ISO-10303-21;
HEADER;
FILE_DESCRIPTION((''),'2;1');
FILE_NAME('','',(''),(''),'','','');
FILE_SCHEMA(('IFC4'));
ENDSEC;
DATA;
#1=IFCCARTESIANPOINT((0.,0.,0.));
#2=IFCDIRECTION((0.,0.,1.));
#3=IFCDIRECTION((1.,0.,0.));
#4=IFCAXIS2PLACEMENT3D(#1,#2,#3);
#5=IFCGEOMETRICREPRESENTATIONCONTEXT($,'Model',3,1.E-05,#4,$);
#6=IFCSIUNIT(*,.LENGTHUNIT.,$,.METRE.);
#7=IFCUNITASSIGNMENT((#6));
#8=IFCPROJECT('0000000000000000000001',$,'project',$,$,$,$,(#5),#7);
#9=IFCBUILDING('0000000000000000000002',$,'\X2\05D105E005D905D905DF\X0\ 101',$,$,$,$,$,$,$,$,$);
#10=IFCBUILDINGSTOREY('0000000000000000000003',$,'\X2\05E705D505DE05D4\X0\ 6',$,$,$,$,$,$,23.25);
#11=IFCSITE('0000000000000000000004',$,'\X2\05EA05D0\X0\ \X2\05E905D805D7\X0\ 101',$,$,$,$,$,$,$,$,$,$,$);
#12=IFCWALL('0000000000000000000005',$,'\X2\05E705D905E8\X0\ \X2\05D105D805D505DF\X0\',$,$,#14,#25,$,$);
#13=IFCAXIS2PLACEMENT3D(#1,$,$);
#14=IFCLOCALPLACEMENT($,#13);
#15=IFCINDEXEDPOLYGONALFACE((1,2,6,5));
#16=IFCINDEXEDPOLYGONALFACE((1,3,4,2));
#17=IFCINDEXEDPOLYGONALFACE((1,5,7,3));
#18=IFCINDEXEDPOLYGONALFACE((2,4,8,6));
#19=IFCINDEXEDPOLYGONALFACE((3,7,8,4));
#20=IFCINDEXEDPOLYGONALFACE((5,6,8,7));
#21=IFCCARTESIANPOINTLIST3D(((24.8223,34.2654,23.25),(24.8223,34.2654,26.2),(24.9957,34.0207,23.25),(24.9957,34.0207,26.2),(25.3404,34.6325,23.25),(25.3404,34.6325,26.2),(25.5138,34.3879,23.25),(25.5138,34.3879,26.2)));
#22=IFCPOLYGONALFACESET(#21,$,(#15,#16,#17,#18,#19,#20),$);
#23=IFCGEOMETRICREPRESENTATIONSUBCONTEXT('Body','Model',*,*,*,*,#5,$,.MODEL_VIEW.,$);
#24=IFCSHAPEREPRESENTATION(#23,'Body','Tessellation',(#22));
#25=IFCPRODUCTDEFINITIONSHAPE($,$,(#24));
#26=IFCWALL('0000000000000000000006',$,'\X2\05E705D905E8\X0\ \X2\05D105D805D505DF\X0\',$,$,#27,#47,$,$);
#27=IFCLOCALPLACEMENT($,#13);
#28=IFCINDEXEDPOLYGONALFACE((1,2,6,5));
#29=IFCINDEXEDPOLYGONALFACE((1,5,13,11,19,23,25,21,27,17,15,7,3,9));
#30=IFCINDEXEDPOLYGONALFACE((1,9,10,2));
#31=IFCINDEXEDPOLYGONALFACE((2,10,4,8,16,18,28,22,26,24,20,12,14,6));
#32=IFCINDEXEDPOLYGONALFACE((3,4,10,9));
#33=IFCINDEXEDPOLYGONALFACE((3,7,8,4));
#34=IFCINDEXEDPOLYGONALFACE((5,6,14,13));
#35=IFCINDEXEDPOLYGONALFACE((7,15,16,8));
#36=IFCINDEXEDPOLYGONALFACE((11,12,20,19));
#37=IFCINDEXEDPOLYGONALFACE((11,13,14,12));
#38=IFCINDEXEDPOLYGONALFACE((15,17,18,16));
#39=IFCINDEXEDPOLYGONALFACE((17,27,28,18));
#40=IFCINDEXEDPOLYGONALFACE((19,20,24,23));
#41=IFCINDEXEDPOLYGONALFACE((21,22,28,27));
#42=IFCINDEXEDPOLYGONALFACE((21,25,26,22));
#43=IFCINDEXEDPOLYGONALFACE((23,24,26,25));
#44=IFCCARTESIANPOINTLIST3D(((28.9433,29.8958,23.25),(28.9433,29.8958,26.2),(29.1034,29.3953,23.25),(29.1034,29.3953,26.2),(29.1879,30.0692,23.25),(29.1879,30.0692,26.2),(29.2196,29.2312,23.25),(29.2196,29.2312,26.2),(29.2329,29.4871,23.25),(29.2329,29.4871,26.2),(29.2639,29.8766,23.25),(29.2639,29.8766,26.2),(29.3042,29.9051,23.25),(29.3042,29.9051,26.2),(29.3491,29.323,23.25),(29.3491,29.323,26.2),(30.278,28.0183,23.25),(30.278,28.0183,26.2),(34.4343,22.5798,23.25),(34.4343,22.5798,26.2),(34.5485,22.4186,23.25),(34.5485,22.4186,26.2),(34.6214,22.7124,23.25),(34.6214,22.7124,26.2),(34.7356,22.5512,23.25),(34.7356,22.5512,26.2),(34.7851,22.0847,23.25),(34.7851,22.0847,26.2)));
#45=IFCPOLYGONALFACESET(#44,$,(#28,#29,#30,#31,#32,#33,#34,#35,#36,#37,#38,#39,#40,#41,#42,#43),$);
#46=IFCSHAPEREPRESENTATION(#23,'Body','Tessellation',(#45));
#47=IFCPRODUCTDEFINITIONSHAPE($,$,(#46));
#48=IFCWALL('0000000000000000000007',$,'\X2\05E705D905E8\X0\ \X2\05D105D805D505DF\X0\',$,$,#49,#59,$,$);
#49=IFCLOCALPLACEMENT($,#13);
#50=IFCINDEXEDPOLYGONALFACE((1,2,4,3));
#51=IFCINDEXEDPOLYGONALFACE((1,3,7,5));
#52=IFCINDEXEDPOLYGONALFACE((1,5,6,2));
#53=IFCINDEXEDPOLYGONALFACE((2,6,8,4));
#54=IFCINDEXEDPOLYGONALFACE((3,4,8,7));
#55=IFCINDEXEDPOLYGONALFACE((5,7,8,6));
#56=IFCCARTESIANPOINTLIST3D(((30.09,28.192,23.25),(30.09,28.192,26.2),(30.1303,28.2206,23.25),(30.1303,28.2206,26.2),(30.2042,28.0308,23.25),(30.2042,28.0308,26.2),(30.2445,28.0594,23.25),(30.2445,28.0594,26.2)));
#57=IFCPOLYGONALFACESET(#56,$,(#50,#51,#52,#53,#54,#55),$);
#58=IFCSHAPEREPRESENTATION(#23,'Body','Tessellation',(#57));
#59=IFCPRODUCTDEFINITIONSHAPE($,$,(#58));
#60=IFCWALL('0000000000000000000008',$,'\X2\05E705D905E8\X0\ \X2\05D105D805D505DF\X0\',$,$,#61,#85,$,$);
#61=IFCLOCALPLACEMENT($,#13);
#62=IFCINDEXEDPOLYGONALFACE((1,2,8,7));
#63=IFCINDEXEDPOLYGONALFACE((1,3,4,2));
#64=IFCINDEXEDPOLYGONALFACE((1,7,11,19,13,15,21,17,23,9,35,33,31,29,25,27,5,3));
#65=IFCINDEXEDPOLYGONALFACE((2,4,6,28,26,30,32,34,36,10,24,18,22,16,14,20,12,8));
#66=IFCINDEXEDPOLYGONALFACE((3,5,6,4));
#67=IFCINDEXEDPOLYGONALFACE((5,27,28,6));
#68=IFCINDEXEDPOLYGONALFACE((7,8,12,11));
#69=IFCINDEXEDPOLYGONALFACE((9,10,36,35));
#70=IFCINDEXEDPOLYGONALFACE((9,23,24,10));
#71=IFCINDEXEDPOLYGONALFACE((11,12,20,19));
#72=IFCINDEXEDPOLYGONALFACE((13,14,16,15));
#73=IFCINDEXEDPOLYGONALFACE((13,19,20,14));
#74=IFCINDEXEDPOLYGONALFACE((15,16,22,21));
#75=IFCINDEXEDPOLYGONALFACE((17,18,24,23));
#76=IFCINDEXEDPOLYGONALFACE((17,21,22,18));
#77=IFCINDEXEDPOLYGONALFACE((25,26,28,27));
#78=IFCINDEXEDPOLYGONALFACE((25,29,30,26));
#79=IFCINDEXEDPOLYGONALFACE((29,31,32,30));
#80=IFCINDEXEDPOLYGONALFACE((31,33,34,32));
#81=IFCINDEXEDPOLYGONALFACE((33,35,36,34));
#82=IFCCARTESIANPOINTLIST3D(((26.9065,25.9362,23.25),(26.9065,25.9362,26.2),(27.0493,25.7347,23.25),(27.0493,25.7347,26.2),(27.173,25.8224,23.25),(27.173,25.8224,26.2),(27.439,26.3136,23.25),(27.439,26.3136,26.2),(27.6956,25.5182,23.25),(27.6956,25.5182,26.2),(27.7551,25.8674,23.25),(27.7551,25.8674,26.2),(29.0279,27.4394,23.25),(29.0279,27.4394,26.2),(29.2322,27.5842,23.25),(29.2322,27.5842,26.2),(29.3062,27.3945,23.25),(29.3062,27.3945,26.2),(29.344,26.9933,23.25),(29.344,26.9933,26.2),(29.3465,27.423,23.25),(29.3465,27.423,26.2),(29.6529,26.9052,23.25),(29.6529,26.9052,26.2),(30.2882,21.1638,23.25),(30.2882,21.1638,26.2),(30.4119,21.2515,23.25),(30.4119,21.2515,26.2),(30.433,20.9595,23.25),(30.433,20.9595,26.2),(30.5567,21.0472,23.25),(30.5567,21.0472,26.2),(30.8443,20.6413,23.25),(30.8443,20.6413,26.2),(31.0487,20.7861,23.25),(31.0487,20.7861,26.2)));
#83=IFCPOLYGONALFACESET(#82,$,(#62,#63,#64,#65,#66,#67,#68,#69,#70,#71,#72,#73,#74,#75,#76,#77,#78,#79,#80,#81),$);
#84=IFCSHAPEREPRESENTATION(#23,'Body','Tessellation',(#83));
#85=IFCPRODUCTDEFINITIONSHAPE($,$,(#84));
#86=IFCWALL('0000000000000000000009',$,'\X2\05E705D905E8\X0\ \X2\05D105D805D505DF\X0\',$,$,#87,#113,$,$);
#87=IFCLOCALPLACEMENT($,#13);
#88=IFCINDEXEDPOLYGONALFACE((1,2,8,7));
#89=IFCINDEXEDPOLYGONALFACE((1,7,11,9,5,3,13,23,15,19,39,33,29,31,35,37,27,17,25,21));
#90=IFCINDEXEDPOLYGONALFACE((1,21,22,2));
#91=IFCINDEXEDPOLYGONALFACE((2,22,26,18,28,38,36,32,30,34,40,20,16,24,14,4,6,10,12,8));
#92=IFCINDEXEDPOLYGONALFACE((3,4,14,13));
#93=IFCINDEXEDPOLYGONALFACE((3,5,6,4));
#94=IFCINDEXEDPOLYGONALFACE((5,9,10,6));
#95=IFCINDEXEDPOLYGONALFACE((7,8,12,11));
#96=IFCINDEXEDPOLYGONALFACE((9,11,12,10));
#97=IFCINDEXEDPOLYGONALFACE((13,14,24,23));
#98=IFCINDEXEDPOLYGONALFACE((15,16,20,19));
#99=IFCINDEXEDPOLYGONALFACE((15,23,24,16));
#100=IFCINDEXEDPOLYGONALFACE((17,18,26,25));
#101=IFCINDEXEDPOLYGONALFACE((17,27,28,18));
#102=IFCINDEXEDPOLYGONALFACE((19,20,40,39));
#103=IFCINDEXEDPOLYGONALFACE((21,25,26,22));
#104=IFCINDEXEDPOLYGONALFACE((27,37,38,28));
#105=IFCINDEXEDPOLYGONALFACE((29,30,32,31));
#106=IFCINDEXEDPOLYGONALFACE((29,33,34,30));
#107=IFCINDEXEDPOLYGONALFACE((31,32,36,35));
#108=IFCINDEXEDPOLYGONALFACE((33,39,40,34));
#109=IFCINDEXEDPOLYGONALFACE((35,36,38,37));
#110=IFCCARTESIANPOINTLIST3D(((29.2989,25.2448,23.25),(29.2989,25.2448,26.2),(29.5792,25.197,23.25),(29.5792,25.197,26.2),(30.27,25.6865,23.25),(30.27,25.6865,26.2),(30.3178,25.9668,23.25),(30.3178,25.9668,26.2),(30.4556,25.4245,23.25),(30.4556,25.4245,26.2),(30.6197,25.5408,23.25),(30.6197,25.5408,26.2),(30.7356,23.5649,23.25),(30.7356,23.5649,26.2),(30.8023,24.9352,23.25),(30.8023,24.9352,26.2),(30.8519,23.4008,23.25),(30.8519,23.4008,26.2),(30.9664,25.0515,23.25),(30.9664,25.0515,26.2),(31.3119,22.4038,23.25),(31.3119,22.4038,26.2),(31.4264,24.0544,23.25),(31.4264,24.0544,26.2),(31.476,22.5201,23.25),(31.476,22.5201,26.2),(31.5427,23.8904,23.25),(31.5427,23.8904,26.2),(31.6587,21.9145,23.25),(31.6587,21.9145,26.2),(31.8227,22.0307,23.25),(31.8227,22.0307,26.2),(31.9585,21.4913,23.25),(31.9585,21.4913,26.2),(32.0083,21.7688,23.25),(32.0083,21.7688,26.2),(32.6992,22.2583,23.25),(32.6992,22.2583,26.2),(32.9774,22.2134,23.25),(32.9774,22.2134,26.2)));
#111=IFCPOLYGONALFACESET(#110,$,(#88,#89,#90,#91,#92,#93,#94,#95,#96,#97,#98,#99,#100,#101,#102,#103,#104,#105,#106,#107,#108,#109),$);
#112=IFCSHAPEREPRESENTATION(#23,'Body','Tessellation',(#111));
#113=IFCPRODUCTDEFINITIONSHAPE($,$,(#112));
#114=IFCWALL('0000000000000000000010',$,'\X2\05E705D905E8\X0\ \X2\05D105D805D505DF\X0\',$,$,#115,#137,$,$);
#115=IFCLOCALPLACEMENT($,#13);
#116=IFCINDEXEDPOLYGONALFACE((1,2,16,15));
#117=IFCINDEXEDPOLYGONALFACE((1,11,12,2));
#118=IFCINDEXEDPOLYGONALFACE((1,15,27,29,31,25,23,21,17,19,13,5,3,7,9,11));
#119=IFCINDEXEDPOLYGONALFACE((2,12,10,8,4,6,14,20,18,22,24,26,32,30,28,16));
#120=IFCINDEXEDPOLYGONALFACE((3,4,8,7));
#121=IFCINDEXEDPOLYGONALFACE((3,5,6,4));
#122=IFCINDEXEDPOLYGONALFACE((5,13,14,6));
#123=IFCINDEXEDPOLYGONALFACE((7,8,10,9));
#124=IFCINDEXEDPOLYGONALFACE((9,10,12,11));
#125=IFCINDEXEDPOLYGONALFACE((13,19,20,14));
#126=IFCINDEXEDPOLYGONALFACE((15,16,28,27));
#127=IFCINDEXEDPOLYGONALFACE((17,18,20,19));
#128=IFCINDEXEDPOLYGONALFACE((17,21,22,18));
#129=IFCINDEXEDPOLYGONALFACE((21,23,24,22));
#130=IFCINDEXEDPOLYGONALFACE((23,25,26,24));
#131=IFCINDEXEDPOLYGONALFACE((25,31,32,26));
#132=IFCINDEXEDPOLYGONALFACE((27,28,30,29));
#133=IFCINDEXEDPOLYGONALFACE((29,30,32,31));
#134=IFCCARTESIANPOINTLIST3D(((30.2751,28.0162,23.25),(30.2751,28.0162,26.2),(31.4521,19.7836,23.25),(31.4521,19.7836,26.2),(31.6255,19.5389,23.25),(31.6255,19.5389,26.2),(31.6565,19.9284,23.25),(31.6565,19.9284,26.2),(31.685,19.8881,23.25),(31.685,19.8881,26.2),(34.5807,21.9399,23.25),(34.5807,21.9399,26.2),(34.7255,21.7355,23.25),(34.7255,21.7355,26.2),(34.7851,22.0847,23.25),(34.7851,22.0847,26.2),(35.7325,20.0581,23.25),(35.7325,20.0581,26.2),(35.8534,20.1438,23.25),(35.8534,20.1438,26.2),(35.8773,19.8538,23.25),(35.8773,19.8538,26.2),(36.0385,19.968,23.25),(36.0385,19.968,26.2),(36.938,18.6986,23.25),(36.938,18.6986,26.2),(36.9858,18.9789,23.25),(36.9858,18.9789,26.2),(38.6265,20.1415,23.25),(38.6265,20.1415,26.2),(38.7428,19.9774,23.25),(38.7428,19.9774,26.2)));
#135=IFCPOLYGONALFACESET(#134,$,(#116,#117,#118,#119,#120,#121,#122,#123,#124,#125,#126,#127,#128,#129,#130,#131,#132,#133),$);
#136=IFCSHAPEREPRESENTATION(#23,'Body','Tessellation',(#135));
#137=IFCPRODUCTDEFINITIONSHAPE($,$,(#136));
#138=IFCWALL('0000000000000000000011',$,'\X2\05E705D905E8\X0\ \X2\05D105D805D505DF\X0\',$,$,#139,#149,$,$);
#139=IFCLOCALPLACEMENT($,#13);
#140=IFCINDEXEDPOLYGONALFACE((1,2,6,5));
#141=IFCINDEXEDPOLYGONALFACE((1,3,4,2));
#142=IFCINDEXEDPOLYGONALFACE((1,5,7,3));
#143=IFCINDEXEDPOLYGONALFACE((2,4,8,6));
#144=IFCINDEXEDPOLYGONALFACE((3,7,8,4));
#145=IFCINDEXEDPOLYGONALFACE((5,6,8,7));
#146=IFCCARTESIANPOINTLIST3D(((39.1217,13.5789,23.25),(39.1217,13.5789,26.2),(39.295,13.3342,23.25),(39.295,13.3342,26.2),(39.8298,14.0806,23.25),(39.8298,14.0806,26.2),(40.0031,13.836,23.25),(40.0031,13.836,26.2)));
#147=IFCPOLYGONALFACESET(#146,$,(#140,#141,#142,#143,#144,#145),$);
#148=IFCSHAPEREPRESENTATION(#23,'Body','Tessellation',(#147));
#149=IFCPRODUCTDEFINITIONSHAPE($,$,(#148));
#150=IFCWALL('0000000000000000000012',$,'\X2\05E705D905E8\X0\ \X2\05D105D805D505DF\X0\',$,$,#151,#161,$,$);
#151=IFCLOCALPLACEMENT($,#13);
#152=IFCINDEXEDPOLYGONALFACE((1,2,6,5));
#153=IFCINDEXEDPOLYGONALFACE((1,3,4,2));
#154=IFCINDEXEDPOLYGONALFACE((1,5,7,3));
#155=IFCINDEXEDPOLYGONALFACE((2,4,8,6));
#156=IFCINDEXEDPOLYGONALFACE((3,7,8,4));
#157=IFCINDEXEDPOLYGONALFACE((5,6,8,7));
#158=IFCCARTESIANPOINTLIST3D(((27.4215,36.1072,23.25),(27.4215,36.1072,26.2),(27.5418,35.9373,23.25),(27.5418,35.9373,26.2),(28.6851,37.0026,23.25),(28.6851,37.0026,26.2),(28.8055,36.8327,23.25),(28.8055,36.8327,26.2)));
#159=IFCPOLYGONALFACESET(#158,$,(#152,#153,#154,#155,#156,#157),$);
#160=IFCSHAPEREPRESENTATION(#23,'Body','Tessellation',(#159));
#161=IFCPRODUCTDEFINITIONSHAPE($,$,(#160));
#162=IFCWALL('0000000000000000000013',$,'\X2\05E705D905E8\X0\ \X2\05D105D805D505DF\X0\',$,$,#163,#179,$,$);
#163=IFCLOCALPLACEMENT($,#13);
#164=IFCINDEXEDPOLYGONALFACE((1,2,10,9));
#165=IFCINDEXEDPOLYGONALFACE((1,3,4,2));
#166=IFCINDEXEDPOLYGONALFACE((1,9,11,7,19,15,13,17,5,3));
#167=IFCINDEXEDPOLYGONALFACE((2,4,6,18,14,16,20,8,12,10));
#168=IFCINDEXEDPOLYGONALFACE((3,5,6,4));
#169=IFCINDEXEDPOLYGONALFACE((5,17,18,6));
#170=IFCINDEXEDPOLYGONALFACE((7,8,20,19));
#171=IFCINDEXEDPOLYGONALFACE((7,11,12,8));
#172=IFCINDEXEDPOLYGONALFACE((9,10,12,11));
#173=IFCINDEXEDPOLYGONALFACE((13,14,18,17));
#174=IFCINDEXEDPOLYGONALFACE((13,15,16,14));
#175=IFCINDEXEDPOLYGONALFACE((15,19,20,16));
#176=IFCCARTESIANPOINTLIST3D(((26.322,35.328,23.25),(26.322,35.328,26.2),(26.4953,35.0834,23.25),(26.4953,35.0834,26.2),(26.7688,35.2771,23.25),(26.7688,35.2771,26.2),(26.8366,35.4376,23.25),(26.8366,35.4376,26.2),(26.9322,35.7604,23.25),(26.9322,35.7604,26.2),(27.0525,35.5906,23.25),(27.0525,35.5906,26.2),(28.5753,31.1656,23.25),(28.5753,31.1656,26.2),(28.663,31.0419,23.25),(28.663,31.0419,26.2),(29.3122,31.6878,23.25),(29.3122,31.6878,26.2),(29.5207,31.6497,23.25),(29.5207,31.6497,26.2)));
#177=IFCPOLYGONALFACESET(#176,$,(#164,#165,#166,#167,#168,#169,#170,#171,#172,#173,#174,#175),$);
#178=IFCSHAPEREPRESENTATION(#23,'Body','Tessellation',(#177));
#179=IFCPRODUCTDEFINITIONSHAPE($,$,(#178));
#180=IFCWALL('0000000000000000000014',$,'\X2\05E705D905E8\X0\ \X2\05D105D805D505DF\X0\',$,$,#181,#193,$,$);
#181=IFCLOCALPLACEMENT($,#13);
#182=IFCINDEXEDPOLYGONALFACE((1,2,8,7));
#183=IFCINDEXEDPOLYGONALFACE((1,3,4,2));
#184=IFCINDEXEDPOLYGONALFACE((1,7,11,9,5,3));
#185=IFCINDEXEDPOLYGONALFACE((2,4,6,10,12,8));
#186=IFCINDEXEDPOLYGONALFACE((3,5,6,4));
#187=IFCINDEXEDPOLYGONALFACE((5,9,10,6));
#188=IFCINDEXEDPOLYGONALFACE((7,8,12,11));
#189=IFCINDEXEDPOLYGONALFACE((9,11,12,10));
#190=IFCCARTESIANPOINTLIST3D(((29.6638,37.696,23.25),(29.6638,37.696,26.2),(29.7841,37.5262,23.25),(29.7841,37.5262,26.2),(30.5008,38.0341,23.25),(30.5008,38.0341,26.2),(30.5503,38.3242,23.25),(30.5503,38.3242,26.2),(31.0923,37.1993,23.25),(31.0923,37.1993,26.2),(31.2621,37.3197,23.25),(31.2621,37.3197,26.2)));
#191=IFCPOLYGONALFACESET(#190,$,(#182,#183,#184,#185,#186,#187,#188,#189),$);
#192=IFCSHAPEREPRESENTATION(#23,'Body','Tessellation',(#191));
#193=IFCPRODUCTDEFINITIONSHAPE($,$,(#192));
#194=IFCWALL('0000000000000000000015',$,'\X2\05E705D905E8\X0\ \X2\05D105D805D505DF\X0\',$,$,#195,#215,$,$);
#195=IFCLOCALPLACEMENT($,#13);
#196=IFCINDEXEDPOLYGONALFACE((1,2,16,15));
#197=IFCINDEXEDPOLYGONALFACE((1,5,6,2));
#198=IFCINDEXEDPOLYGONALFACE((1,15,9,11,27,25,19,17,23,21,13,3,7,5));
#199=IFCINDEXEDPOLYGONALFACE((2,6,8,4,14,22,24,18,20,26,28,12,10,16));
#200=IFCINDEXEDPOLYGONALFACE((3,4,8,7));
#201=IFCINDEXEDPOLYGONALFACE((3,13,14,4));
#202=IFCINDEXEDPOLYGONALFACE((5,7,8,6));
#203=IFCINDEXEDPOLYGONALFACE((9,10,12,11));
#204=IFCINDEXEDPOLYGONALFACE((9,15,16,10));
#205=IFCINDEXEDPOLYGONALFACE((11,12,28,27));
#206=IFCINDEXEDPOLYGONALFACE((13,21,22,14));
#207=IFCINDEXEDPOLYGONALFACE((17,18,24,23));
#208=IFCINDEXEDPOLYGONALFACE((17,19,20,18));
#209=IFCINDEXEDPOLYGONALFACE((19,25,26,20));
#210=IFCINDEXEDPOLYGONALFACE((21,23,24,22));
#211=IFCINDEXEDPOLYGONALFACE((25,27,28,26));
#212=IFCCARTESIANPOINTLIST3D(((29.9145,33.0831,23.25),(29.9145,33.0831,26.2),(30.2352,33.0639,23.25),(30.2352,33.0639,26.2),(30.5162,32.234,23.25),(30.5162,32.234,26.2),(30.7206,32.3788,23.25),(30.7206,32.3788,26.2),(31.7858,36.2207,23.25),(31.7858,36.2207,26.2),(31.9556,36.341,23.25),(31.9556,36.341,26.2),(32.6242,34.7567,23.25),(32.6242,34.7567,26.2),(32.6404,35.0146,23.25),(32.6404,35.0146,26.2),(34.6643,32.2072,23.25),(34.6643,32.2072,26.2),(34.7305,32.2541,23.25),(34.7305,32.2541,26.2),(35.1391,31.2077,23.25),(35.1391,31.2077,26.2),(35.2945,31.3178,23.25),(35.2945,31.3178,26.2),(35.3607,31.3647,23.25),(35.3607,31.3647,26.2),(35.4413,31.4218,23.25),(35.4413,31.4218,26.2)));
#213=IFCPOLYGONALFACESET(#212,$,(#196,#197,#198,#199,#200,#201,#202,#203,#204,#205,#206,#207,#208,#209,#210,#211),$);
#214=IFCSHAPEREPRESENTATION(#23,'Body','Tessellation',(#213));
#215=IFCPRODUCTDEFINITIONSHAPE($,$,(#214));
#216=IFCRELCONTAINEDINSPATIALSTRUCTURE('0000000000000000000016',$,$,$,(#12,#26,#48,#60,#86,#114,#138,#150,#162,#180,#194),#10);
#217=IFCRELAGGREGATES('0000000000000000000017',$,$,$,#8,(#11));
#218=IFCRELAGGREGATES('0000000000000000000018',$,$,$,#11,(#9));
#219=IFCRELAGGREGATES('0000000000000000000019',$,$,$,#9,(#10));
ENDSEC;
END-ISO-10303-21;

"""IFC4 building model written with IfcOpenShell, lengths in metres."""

from ifc_helpers import new_model, si_unit, frame, origin_with_axes, context, subcontext, project, spatial, polyline, outline, extrude, element, save


model = new_model("IFC4")

# Units and contexts
model_context = context("Model", 3, precision=1e-05, world=origin_with_axes())
body_context = subcontext(model_context, "Body", "Model", "MODEL_VIEW")
ifc_project = project(units=[si_unit("LENGTHUNIT", "METRE")], contexts=[model_context])

# Site, building, storey
site = spatial("IfcSite", under=ifc_project, Name="תא שטח 101")
building = spatial("IfcBuilding", under=site, Name="בניין 101")
storey = spatial("IfcBuildingStorey", under=building, Name="קומה 6", Elevation=23.25)

# Walls
element("IfcWall", 1, inside=storey, Name="קיר בטון", context=body_context, shape_type="SweptSolid", body=[
    extrude(outline(polyline([(25.3404, 34.6325), (24.8223, 34.2654), (24.9957, 34.0207), (25.5138, 34.3879), (25.3404, 34.6325)])), frame((0.0, 0.0, 23.25)), (0.0, 0.0, 1.0), 2.95),
])
element("IfcWall", 2, inside=storey, Name="קיר בטון", context=body_context, shape_type="SweptSolid", body=[
    extrude(outline(polyline([(28.9433, 29.8958), (29.2329, 29.4871), (29.1034, 29.3953), (29.2196, 29.2312), (29.3491, 29.323), (30.278, 28.0183), (34.7851, 22.0847), (34.5485, 22.4186), (34.7356, 22.5512), (34.6214, 22.7124), (34.4343, 22.5798), (29.2639, 29.8766), (29.3042, 29.9051), (29.1879, 30.0692), (28.9433, 29.8958)])), frame((0.0, 0.0, 23.25)), (0.0, 0.0, 1.0), 2.95),
])
element("IfcWall", 3, inside=storey, Name="קיר בטון", context=body_context, shape_type="SweptSolid", body=[
    extrude(outline(polyline([(30.09, 28.192), (30.2042, 28.0308), (30.2445, 28.0594), (30.1303, 28.2206), (30.09, 28.192)])), frame((0.0, 0.0, 23.25)), (0.0, 0.0, 1.0), 2.95),
])
element("IfcWall", 4, inside=storey, Name="קיר בטון", context=body_context, shape_type="SweptSolid", body=[
    extrude(outline(polyline([(27.7551, 25.8674), (27.439, 26.3136), (26.9065, 25.9362), (27.0493, 25.7347), (27.173, 25.8224), (30.4119, 21.2515), (30.2882, 21.1638), (30.433, 20.9595), (30.5567, 21.0472), (30.8443, 20.6413), (31.0487, 20.7861), (27.6956, 25.5182), (29.6529, 26.9052), (29.3062, 27.3945), (29.3465, 27.423), (29.2322, 27.5842), (29.0279, 27.4394), (29.344, 26.9933), (27.7551, 25.8674)])), frame((0.0, 0.0, 23.25)), (0.0, 0.0, 1.0), 2.95),
])
element("IfcWall", 5, inside=storey, Name="קיר בטון", context=body_context, shape_type="SweptSolid", body=[
    extrude(outline(polyline([(30.6197, 25.5408), (30.3178, 25.9668), (29.2989, 25.2448), (31.3119, 22.4038), (31.476, 22.5201), (30.8519, 23.4008), (31.5427, 23.8904), (32.6992, 22.2583), (32.0083, 21.7688), (31.8227, 22.0307), (31.6587, 21.9145), (31.9585, 21.4913), (32.9774, 22.2134), (30.9664, 25.0515), (30.8023, 24.9352), (31.4264, 24.0544), (30.7356, 23.5649), (29.5792, 25.197), (30.27, 25.6865), (30.4556, 25.4245), (30.6197, 25.5408)])), frame((0.0, 0.0, 23.25)), (0.0, 0.0, 1.0), 2.95),
])
element("IfcWall", 6, inside=storey, Name="קיר בטון", context=body_context, shape_type="SweptSolid", body=[
    extrude(outline(polyline([(31.6565, 19.9284), (31.4521, 19.7836), (31.6255, 19.5389), (34.7255, 21.7355), (35.8534, 20.1438), (35.7325, 20.0581), (35.8773, 19.8538), (36.0385, 19.968), (36.938, 18.6986), (38.7428, 19.9774), (38.6265, 20.1415), (36.9858, 18.9789), (34.7851, 22.0847), (30.2751, 28.0162), (34.5807, 21.9399), (31.685, 19.8881), (31.6565, 19.9284)])), frame((0.0, 0.0, 23.25)), (0.0, 0.0, 1.0), 2.95),
])
element("IfcWall", 7, inside=storey, Name="קיר בטון", context=body_context, shape_type="SweptSolid", body=[
    extrude(outline(polyline([(40.0031, 13.836), (39.8298, 14.0806), (39.1217, 13.5789), (39.295, 13.3342), (40.0031, 13.836)])), frame((0.0, 0.0, 23.25)), (0.0, 0.0, 1.0), 2.95),
])
element("IfcWall", 8, inside=storey, Name="קיר בטון", context=body_context, shape_type="SweptSolid", body=[
    extrude(outline(polyline([(28.6851, 37.0026), (27.4215, 36.1072), (27.5418, 35.9373), (28.8055, 36.8327), (28.6851, 37.0026)])), frame((0.0, 0.0, 23.25)), (0.0, 0.0, 1.0), 2.95),
])
element("IfcWall", 9, inside=storey, Name="קיר בטון", context=body_context, shape_type="SweptSolid", body=[
    extrude(outline(polyline([(29.3122, 31.6878), (28.5753, 31.1656), (28.663, 31.0419), (29.5207, 31.6497), (26.8366, 35.4376), (27.0525, 35.5906), (26.9322, 35.7604), (26.322, 35.328), (26.4953, 35.0834), (26.7688, 35.2771), (29.3122, 31.6878)])), frame((0.0, 0.0, 23.25)), (0.0, 0.0, 1.0), 2.95),
])
element("IfcWall", 10, inside=storey, Name="קיר בטון", context=body_context, shape_type="SweptSolid", body=[
    extrude(outline(polyline([(31.2621, 37.3197), (30.5503, 38.3242), (29.6638, 37.696), (29.7841, 37.5262), (30.5008, 38.0341), (31.0923, 37.1993), (31.2621, 37.3197)])), frame((0.0, 0.0, 23.25)), (0.0, 0.0, 1.0), 2.95),
])
element("IfcWall", 11, inside=storey, Name="קיר בטון", context=body_context, shape_type="SweptSolid", body=[
    extrude(outline(polyline([(29.9145, 33.0831), (30.5162, 32.234), (30.7206, 32.3788), (30.2352, 33.0639), (32.6242, 34.7567), (35.1391, 31.2077), (35.2945, 31.3178), (34.6643, 32.2072), (34.7305, 32.2541), (35.3607, 31.3647), (35.4413, 31.4218), (31.9556, 36.341), (31.7858, 36.2207), (32.6404, 35.0146), (29.9145, 33.0831)])), frame((0.0, 0.0, 23.25)), (0.0, 0.0, 1.0), 2.95),
])

save(model, "model.ifc")
